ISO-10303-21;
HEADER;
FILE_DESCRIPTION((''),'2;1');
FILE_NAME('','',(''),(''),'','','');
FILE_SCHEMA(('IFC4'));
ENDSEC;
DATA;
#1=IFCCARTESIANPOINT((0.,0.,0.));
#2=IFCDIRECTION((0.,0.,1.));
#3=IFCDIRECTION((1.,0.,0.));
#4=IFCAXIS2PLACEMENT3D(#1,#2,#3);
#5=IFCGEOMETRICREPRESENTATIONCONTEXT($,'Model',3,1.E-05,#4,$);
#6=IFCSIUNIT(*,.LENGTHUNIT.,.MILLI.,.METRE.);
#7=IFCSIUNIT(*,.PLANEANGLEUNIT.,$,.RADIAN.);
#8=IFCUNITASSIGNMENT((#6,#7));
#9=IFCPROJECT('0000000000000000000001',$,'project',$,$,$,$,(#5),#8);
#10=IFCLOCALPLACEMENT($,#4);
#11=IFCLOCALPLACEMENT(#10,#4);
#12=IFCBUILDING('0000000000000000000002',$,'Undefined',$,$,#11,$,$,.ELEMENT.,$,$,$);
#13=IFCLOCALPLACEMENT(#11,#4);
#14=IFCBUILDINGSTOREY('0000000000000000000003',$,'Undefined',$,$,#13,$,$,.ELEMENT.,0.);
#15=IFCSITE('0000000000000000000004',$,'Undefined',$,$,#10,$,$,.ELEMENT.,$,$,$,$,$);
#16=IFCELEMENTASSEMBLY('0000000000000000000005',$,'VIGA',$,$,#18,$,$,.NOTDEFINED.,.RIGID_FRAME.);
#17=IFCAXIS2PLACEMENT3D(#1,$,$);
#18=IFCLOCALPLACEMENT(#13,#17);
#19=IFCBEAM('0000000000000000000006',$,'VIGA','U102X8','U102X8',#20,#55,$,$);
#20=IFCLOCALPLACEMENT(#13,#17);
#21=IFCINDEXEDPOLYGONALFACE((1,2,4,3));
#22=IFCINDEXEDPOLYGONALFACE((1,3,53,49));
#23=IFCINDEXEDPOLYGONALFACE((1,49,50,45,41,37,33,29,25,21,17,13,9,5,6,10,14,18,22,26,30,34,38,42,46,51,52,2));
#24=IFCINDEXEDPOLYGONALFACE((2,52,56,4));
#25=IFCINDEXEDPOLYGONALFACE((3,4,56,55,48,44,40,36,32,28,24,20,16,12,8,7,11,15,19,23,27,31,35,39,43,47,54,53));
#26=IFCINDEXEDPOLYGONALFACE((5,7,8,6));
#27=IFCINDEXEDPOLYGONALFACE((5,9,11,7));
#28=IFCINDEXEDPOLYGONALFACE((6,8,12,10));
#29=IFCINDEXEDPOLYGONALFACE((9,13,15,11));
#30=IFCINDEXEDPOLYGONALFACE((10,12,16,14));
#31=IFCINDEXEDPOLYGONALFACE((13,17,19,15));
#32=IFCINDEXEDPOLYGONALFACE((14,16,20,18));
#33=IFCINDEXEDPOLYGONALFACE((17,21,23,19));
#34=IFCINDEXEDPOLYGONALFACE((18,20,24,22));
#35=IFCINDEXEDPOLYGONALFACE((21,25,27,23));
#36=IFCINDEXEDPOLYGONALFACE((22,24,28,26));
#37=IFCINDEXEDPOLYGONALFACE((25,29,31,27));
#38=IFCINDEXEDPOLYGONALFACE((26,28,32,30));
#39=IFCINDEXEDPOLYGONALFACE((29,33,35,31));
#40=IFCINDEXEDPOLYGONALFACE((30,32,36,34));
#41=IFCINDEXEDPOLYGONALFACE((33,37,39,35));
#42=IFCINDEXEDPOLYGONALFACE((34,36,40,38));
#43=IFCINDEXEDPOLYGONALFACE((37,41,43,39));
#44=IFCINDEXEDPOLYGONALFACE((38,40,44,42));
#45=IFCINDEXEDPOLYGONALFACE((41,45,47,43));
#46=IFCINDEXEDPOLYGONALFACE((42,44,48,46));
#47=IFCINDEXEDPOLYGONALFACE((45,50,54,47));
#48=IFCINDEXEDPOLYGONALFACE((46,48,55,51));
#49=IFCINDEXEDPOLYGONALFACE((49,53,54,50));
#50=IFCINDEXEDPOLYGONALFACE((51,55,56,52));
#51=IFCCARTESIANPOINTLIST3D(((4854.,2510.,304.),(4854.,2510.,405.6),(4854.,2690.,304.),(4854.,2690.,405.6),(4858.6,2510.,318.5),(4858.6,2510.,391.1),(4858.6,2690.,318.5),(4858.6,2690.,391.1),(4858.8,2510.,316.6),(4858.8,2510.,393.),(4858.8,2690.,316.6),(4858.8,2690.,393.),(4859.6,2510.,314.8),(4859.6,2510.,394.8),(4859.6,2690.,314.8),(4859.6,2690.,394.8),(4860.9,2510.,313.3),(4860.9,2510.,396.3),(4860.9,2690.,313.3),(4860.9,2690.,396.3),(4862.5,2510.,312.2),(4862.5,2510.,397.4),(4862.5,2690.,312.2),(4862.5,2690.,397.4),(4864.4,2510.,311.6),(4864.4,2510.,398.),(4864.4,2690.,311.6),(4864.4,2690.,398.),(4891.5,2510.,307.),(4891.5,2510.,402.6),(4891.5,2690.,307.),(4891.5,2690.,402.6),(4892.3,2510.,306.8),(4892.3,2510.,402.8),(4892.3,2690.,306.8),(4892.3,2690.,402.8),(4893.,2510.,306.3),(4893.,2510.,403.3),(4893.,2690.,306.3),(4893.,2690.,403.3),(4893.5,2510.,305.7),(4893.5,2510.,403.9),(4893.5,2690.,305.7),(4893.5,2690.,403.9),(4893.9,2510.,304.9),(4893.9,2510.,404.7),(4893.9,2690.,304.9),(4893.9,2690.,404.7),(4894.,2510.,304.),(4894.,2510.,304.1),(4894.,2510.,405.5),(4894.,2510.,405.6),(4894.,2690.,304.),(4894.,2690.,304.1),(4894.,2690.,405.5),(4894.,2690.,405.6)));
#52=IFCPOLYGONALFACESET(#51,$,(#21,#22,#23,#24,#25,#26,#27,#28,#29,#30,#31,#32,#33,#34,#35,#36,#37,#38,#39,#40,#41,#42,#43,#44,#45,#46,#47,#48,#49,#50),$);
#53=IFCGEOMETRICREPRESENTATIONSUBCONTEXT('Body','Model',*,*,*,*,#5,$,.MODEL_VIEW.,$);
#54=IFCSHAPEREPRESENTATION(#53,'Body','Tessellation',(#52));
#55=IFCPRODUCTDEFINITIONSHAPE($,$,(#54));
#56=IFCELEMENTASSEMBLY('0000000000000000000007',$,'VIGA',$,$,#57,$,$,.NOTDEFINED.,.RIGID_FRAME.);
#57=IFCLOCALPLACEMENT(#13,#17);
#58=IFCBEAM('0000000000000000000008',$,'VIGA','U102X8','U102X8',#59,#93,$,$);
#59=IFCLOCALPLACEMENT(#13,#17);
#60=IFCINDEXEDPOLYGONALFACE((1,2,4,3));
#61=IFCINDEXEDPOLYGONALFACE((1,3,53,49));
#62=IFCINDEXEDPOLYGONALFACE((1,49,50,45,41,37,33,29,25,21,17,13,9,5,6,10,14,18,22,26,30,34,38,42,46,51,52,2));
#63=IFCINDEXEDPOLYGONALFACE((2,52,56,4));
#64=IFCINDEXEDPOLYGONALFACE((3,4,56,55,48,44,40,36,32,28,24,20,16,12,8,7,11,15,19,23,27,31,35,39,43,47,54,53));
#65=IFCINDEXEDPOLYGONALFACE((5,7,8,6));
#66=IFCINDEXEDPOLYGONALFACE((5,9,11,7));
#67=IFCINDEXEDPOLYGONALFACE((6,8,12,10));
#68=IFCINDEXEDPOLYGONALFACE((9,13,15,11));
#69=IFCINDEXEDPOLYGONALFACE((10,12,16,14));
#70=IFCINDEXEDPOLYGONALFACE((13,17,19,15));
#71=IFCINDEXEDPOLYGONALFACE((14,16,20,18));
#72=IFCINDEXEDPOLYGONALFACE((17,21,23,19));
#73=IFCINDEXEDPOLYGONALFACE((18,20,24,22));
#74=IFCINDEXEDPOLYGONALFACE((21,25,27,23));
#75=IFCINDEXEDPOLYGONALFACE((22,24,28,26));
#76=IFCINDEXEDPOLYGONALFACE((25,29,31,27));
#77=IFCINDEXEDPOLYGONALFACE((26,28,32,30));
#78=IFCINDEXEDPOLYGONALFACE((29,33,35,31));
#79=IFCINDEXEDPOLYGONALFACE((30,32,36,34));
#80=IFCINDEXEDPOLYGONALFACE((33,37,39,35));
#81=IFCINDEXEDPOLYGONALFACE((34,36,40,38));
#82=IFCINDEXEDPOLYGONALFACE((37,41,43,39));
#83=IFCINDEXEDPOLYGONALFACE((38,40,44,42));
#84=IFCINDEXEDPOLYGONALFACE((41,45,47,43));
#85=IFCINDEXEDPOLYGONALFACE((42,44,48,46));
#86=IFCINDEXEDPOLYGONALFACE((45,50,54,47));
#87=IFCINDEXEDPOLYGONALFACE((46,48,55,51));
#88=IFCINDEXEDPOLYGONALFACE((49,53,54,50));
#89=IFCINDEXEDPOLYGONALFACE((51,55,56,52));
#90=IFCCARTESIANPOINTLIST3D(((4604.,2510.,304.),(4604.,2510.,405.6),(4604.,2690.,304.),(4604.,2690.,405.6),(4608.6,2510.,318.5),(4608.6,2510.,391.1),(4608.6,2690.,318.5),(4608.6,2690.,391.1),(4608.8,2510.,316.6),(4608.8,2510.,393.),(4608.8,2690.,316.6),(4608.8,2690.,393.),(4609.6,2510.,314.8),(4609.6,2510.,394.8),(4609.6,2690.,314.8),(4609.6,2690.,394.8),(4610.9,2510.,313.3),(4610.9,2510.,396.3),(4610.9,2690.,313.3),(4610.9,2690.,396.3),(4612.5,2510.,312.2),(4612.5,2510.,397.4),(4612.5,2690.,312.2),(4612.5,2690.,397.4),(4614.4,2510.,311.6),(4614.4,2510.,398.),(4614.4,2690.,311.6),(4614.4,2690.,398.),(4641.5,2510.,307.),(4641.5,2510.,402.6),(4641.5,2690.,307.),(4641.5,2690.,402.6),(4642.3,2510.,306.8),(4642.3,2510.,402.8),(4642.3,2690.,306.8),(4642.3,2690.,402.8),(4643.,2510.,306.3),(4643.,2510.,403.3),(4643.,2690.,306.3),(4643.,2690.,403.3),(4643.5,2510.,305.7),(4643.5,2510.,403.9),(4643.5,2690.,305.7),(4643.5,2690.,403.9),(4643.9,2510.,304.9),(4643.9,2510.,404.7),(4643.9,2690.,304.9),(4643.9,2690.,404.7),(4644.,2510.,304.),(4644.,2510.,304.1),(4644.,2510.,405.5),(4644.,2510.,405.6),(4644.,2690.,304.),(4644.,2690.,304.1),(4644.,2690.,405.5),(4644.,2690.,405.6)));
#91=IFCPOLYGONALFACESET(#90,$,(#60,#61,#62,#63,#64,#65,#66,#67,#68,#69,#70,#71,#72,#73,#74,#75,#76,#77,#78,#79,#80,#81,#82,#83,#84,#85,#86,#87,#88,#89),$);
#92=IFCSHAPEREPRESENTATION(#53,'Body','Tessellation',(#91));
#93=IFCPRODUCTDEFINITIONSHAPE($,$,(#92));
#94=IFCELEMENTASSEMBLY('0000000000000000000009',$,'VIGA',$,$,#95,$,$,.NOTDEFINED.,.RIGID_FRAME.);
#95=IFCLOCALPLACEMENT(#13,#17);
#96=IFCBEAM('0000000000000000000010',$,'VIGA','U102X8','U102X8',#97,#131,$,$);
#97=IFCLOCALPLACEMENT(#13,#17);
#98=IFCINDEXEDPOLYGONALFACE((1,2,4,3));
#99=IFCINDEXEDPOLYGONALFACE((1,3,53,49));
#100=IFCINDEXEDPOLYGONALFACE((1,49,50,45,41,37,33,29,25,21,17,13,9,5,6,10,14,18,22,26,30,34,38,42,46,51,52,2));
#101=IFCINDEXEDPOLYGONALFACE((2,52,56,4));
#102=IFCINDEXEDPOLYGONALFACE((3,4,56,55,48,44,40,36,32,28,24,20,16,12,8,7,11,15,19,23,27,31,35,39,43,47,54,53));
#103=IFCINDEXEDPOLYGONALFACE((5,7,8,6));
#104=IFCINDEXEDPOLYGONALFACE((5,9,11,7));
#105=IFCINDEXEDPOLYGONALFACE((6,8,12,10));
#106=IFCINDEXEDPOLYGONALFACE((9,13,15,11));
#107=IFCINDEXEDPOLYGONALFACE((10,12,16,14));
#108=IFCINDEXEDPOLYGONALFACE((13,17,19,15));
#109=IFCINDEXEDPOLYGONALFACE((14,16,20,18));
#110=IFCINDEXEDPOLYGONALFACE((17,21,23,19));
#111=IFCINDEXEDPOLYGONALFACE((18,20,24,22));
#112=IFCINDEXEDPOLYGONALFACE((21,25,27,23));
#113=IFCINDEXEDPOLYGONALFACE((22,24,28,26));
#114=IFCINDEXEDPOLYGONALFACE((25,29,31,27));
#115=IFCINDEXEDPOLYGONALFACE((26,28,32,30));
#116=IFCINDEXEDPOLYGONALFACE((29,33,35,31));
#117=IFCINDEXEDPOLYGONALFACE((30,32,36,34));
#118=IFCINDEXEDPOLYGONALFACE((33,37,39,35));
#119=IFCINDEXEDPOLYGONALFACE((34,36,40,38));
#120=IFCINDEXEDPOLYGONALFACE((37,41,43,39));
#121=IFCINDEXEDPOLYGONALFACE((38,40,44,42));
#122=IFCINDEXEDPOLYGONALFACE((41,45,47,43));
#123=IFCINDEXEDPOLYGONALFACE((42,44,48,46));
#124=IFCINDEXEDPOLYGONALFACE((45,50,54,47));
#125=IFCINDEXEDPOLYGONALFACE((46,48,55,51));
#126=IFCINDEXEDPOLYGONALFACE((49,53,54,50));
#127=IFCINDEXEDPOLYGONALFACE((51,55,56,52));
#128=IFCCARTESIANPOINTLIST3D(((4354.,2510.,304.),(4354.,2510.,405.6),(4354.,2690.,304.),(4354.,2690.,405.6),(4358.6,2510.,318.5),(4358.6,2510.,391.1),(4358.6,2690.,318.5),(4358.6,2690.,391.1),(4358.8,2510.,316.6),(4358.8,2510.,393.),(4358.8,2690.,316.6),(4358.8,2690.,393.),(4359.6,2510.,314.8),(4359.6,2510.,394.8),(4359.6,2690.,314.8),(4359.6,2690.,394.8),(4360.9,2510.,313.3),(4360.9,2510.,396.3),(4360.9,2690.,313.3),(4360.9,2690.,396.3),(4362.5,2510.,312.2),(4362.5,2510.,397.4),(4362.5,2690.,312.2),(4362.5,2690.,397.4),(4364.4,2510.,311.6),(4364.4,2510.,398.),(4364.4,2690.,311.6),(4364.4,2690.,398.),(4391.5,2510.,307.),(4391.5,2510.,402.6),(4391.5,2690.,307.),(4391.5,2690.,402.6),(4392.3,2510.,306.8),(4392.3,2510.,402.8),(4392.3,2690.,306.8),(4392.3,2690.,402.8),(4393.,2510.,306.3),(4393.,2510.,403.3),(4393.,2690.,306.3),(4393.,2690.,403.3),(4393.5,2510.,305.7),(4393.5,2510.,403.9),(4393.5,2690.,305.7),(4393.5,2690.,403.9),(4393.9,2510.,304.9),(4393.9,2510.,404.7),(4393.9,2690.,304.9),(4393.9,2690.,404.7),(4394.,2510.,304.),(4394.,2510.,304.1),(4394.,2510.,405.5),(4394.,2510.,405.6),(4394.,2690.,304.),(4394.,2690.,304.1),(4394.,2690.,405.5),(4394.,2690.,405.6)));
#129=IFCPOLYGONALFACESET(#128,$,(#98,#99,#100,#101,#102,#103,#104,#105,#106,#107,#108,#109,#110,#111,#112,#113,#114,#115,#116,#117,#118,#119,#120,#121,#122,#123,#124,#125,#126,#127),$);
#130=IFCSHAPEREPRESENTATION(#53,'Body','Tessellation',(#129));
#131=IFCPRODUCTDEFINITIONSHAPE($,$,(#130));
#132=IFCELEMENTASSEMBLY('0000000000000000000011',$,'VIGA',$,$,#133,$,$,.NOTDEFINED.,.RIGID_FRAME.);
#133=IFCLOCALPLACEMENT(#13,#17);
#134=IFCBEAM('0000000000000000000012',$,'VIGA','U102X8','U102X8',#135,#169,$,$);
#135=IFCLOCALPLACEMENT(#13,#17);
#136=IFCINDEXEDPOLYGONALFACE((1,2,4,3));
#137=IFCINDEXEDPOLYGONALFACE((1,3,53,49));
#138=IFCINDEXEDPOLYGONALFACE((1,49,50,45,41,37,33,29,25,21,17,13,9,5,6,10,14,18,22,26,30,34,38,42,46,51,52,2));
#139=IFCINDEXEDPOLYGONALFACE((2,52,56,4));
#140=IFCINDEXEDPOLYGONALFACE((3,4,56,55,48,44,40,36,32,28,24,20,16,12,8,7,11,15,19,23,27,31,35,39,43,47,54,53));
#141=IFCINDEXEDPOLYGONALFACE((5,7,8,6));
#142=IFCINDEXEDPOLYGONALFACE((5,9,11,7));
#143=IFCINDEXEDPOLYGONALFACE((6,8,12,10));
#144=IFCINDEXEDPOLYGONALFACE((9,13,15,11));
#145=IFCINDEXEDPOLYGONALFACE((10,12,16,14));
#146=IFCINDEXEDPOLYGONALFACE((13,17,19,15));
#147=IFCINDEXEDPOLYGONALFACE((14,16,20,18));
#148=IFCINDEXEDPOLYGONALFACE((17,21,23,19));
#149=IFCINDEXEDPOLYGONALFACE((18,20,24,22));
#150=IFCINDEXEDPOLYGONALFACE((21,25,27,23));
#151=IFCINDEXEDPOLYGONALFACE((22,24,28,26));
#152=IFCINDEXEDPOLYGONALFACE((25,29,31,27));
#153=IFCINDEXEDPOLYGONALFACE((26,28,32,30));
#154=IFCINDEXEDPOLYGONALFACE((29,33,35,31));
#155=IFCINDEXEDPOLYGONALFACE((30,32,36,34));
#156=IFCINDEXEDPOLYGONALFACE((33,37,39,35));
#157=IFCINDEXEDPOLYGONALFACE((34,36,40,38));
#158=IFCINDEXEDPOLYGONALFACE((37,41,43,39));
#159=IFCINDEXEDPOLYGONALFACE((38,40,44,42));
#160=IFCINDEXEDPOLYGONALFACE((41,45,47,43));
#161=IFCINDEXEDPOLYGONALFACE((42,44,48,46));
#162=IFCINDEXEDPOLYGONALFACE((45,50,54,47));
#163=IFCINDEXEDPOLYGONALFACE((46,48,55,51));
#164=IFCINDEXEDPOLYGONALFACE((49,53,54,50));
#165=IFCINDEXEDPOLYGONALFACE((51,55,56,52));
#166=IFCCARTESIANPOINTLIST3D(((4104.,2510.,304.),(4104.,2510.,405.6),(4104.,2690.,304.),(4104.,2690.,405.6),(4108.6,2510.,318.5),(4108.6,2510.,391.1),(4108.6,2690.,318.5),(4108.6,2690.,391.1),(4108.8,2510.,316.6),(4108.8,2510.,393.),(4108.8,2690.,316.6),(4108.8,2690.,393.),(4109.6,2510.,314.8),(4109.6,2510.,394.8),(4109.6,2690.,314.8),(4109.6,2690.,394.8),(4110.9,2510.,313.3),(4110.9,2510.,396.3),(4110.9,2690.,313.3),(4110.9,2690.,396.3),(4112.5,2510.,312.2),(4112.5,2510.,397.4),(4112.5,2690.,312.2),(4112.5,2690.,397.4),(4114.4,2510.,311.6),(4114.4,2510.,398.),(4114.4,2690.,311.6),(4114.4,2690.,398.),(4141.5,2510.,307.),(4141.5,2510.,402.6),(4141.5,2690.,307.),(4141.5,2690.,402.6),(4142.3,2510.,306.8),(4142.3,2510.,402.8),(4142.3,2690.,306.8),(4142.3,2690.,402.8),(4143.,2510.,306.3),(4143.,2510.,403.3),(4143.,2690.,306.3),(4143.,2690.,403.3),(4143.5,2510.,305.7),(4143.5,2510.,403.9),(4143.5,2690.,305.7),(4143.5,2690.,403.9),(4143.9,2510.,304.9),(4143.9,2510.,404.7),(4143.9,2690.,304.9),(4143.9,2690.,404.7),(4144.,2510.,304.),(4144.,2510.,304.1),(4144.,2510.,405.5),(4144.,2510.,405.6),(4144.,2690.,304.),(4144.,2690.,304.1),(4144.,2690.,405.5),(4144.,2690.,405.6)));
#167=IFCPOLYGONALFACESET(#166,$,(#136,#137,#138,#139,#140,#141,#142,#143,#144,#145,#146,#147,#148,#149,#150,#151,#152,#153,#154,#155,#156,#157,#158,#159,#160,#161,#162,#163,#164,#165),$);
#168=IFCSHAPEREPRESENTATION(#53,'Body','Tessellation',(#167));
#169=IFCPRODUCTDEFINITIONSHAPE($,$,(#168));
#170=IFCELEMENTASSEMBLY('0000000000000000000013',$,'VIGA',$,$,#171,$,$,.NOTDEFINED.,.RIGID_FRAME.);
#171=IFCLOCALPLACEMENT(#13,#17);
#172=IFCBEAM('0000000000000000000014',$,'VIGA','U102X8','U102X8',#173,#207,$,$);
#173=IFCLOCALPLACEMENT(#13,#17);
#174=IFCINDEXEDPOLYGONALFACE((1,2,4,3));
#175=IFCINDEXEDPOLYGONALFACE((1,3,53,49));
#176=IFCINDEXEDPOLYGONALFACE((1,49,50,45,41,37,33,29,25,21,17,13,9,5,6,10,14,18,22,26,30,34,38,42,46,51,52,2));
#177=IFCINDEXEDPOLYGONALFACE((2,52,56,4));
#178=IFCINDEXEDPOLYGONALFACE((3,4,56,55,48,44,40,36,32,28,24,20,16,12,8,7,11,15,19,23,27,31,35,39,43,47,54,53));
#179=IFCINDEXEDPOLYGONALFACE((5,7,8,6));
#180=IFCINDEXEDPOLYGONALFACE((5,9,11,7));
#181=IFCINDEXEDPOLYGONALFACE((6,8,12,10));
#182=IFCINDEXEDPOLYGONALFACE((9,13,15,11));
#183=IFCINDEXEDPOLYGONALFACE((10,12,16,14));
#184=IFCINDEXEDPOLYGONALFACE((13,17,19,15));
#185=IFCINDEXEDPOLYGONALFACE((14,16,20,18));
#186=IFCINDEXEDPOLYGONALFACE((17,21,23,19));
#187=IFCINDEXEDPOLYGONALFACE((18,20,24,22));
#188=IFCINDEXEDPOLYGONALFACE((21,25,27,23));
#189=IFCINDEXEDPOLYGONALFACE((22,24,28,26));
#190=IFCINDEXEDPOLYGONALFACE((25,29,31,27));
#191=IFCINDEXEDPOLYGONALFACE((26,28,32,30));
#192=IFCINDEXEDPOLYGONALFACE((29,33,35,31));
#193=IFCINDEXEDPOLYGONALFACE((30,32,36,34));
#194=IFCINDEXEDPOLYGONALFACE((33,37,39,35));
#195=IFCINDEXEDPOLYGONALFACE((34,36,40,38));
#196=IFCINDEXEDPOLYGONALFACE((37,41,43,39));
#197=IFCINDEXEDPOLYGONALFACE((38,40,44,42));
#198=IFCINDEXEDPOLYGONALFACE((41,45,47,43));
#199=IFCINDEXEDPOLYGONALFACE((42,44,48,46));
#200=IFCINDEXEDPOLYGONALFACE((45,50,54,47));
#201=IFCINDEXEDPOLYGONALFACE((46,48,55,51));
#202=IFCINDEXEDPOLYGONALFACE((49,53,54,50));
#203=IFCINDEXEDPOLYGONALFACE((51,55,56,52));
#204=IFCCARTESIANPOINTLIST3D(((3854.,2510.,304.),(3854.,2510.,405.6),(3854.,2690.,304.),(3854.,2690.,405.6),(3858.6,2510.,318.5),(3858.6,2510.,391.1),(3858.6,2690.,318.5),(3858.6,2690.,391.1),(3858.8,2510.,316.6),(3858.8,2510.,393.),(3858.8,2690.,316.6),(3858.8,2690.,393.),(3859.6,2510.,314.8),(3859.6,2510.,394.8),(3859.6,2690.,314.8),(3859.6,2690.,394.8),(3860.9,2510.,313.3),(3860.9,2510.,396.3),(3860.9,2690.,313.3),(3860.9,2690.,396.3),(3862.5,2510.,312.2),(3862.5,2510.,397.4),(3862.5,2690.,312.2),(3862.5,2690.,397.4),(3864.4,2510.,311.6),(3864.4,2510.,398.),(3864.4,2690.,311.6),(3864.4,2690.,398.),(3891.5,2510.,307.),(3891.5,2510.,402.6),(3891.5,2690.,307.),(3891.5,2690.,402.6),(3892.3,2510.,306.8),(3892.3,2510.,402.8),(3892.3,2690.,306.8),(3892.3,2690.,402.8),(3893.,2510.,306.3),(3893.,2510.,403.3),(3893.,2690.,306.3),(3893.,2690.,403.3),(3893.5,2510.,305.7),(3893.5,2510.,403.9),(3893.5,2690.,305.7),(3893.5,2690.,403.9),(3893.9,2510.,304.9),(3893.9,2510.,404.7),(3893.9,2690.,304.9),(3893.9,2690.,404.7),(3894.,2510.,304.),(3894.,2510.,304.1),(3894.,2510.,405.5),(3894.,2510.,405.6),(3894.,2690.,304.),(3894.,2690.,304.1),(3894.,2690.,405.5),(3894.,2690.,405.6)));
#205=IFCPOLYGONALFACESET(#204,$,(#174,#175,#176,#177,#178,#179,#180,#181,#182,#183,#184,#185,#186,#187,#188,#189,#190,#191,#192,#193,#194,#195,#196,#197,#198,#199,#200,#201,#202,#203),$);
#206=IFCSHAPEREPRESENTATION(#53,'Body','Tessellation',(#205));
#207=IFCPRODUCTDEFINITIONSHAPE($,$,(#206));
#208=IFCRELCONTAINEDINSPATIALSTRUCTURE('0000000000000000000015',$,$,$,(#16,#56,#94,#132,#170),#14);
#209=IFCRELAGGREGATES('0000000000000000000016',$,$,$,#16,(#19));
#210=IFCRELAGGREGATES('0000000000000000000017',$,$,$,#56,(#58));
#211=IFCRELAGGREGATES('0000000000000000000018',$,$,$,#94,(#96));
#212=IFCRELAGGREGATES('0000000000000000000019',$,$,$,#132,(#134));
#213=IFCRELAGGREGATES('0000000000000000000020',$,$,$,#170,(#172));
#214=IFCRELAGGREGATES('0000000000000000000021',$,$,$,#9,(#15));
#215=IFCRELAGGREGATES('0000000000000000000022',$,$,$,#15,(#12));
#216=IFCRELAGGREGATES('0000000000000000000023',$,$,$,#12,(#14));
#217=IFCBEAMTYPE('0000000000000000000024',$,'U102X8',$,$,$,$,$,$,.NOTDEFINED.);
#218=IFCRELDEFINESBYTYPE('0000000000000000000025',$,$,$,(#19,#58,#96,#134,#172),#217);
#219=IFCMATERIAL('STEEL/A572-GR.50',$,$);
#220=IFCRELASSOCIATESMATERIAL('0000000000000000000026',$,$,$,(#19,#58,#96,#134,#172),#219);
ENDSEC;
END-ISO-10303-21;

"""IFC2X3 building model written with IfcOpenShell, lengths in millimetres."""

from ifc_helpers import new_model, si_unit, frame, origin_with_axes, origin_2d_with_axis, place, context, subcontext, project, spatial, u_section, extrude, material, type_object, element, aggregate, save


model = new_model("IFC2X3")

# Units and contexts
model_context = context("Model", 3, precision=1e-05, world=origin_with_axes())
body_context = subcontext(model_context, "Body", "Model", "MODEL_VIEW")
ifc_project = project(units=[si_unit("LENGTHUNIT", "METRE", prefix="MILLI"), si_unit("PLANEANGLEUNIT", "RADIAN")], contexts=[model_context])

# Site, building, storey
site_placement = place(None, origin_with_axes())
site = spatial("IfcSite", under=ifc_project, at=site_placement, Name="Undefined", CompositionType="ELEMENT")
building_placement = place(site_placement, origin_with_axes())
building = spatial("IfcBuilding", under=site, at=building_placement, Name="Undefined", CompositionType="ELEMENT")
storey_placement = place(building_placement, origin_with_axes())
storey = spatial("IfcBuildingStorey", under=building, at=storey_placement, Name="Undefined", CompositionType="ELEMENT", Elevation=0.0)

# Element assemblies, beams
assembly_1_placement = place(storey_placement, origin_with_axes())
assembly_1 = element("IfcElementAssembly", 1, at=assembly_1_placement, inside=storey, Name="VIGA", AssemblyPlace="NOTDEFINED", PredefinedType="RIGID_FRAME")
ifc_material_1 = material(Name="STEEL/A572-GR.50")
beam_type = type_object("IfcBeamType", Name="U102X8", PredefinedType="NOTDEFINED")
beam_1_placement = place(assembly_1_placement, frame((4874.0, 2510.0, 354.8), z_axis=(0.0, 0.0, 1.0), x_axis=(0.0, 1.0, 0.0)))
beam_1 = element("IfcBeam", 2, at=beam_1_placement, type_object=beam_type, material=ifc_material_1, Name="VIGA", Description="U102X8", ObjectType="U102X8", context=body_context, shape_type="SweptSolid", body=[
    extrude(u_section(Depth=101.6, FlangeWidth=40.0, WebThickness=4.6, FlangeThickness=6.0, FilletRadius=7.0, EdgeRadius=3.0, FlangeSlope=0.16839, at=origin_2d_with_axis()), frame((180.0, 0.0, 0.0), z_axis=(-1.0, 0.0, 0.0), x_axis=(0.0, -1.0, 0.0)), (0.0, 0.0, 1.0), 180.0),
])
aggregate(assembly_1, [beam_1])
assembly_2_placement = place(storey_placement, origin_with_axes())
assembly_2 = element("IfcElementAssembly", 3, at=assembly_2_placement, inside=storey, Name="VIGA", AssemblyPlace="NOTDEFINED", PredefinedType="RIGID_FRAME")
beam_2_placement = place(assembly_2_placement, frame((4624.0, 2510.0, 354.8), z_axis=(0.0, 0.0, 1.0), x_axis=(0.0, 1.0, 0.0)))
beam_2 = element("IfcBeam", 4, at=beam_2_placement, type_object=beam_type, material=ifc_material_1, Name="VIGA", Description="U102X8", ObjectType="U102X8", context=body_context, shape_type="SweptSolid", body=[
    extrude(u_section(Depth=101.6, FlangeWidth=40.0, WebThickness=4.6, FlangeThickness=6.0, FilletRadius=7.0, EdgeRadius=3.0, FlangeSlope=0.16839, at=origin_2d_with_axis()), frame((180.0, 0.0, 0.0), z_axis=(-1.0, 0.0, 0.0), x_axis=(0.0, -1.0, 0.0)), (0.0, 0.0, 1.0), 180.0),
])
aggregate(assembly_2, [beam_2])
assembly_3_placement = place(storey_placement, origin_with_axes())
assembly_3 = element("IfcElementAssembly", 5, at=assembly_3_placement, inside=storey, Name="VIGA", AssemblyPlace="NOTDEFINED", PredefinedType="RIGID_FRAME")
beam_3_placement = place(assembly_3_placement, frame((4374.0, 2510.0, 354.8), z_axis=(0.0, 0.0, 1.0), x_axis=(0.0, 1.0, 0.0)))
beam_3 = element("IfcBeam", 6, at=beam_3_placement, type_object=beam_type, material=ifc_material_1, Name="VIGA", Description="U102X8", ObjectType="U102X8", context=body_context, shape_type="SweptSolid", body=[
    extrude(u_section(Depth=101.6, FlangeWidth=40.0, WebThickness=4.6, FlangeThickness=6.0, FilletRadius=7.0, EdgeRadius=3.0, FlangeSlope=0.16839, at=origin_2d_with_axis()), frame((180.0, 0.0, 0.0), z_axis=(-1.0, 0.0, 0.0), x_axis=(0.0, -1.0, 0.0)), (0.0, 0.0, 1.0), 180.0),
])
aggregate(assembly_3, [beam_3])
assembly_4_placement = place(storey_placement, origin_with_axes())
assembly_4 = element("IfcElementAssembly", 7, at=assembly_4_placement, inside=storey, Name="VIGA", AssemblyPlace="NOTDEFINED", PredefinedType="RIGID_FRAME")
beam_4_placement = place(assembly_4_placement, frame((4124.0, 2510.0, 354.8), z_axis=(0.0, 0.0, 1.0), x_axis=(0.0, 1.0, 0.0)))
beam_4 = element("IfcBeam", 8, at=beam_4_placement, type_object=beam_type, material=ifc_material_1, Name="VIGA", Description="U102X8", ObjectType="U102X8", context=body_context, shape_type="SweptSolid", body=[
    extrude(u_section(Depth=101.6, FlangeWidth=40.0, WebThickness=4.6, FlangeThickness=6.0, FilletRadius=7.0, EdgeRadius=3.0, FlangeSlope=0.16839, at=origin_2d_with_axis()), frame((180.0, 0.0, 0.0), z_axis=(-1.0, 0.0, 0.0), x_axis=(0.0, -1.0, 0.0)), (0.0, 0.0, 1.0), 180.0),
])
aggregate(assembly_4, [beam_4])
assembly_5_placement = place(storey_placement, origin_with_axes())
assembly_5 = element("IfcElementAssembly", 9, at=assembly_5_placement, inside=storey, Name="VIGA", AssemblyPlace="NOTDEFINED", PredefinedType="RIGID_FRAME")
beam_5_placement = place(assembly_5_placement, frame((3874.0, 2510.0, 354.8), z_axis=(0.0, 0.0, 1.0), x_axis=(0.0, 1.0, 0.0)))
beam_5 = element("IfcBeam", 10, at=beam_5_placement, type_object=beam_type, material=ifc_material_1, Name="VIGA", Description="U102X8", ObjectType="U102X8", context=body_context, shape_type="SweptSolid", body=[
    extrude(u_section(Depth=101.6, FlangeWidth=40.0, WebThickness=4.6, FlangeThickness=6.0, FilletRadius=7.0, EdgeRadius=3.0, FlangeSlope=0.16839, at=origin_2d_with_axis()), frame((180.0, 0.0, 0.0), z_axis=(-1.0, 0.0, 0.0), x_axis=(0.0, -1.0, 0.0)), (0.0, 0.0, 1.0), 180.0),
])
aggregate(assembly_5, [beam_5])

save(model, "model.ifc")
